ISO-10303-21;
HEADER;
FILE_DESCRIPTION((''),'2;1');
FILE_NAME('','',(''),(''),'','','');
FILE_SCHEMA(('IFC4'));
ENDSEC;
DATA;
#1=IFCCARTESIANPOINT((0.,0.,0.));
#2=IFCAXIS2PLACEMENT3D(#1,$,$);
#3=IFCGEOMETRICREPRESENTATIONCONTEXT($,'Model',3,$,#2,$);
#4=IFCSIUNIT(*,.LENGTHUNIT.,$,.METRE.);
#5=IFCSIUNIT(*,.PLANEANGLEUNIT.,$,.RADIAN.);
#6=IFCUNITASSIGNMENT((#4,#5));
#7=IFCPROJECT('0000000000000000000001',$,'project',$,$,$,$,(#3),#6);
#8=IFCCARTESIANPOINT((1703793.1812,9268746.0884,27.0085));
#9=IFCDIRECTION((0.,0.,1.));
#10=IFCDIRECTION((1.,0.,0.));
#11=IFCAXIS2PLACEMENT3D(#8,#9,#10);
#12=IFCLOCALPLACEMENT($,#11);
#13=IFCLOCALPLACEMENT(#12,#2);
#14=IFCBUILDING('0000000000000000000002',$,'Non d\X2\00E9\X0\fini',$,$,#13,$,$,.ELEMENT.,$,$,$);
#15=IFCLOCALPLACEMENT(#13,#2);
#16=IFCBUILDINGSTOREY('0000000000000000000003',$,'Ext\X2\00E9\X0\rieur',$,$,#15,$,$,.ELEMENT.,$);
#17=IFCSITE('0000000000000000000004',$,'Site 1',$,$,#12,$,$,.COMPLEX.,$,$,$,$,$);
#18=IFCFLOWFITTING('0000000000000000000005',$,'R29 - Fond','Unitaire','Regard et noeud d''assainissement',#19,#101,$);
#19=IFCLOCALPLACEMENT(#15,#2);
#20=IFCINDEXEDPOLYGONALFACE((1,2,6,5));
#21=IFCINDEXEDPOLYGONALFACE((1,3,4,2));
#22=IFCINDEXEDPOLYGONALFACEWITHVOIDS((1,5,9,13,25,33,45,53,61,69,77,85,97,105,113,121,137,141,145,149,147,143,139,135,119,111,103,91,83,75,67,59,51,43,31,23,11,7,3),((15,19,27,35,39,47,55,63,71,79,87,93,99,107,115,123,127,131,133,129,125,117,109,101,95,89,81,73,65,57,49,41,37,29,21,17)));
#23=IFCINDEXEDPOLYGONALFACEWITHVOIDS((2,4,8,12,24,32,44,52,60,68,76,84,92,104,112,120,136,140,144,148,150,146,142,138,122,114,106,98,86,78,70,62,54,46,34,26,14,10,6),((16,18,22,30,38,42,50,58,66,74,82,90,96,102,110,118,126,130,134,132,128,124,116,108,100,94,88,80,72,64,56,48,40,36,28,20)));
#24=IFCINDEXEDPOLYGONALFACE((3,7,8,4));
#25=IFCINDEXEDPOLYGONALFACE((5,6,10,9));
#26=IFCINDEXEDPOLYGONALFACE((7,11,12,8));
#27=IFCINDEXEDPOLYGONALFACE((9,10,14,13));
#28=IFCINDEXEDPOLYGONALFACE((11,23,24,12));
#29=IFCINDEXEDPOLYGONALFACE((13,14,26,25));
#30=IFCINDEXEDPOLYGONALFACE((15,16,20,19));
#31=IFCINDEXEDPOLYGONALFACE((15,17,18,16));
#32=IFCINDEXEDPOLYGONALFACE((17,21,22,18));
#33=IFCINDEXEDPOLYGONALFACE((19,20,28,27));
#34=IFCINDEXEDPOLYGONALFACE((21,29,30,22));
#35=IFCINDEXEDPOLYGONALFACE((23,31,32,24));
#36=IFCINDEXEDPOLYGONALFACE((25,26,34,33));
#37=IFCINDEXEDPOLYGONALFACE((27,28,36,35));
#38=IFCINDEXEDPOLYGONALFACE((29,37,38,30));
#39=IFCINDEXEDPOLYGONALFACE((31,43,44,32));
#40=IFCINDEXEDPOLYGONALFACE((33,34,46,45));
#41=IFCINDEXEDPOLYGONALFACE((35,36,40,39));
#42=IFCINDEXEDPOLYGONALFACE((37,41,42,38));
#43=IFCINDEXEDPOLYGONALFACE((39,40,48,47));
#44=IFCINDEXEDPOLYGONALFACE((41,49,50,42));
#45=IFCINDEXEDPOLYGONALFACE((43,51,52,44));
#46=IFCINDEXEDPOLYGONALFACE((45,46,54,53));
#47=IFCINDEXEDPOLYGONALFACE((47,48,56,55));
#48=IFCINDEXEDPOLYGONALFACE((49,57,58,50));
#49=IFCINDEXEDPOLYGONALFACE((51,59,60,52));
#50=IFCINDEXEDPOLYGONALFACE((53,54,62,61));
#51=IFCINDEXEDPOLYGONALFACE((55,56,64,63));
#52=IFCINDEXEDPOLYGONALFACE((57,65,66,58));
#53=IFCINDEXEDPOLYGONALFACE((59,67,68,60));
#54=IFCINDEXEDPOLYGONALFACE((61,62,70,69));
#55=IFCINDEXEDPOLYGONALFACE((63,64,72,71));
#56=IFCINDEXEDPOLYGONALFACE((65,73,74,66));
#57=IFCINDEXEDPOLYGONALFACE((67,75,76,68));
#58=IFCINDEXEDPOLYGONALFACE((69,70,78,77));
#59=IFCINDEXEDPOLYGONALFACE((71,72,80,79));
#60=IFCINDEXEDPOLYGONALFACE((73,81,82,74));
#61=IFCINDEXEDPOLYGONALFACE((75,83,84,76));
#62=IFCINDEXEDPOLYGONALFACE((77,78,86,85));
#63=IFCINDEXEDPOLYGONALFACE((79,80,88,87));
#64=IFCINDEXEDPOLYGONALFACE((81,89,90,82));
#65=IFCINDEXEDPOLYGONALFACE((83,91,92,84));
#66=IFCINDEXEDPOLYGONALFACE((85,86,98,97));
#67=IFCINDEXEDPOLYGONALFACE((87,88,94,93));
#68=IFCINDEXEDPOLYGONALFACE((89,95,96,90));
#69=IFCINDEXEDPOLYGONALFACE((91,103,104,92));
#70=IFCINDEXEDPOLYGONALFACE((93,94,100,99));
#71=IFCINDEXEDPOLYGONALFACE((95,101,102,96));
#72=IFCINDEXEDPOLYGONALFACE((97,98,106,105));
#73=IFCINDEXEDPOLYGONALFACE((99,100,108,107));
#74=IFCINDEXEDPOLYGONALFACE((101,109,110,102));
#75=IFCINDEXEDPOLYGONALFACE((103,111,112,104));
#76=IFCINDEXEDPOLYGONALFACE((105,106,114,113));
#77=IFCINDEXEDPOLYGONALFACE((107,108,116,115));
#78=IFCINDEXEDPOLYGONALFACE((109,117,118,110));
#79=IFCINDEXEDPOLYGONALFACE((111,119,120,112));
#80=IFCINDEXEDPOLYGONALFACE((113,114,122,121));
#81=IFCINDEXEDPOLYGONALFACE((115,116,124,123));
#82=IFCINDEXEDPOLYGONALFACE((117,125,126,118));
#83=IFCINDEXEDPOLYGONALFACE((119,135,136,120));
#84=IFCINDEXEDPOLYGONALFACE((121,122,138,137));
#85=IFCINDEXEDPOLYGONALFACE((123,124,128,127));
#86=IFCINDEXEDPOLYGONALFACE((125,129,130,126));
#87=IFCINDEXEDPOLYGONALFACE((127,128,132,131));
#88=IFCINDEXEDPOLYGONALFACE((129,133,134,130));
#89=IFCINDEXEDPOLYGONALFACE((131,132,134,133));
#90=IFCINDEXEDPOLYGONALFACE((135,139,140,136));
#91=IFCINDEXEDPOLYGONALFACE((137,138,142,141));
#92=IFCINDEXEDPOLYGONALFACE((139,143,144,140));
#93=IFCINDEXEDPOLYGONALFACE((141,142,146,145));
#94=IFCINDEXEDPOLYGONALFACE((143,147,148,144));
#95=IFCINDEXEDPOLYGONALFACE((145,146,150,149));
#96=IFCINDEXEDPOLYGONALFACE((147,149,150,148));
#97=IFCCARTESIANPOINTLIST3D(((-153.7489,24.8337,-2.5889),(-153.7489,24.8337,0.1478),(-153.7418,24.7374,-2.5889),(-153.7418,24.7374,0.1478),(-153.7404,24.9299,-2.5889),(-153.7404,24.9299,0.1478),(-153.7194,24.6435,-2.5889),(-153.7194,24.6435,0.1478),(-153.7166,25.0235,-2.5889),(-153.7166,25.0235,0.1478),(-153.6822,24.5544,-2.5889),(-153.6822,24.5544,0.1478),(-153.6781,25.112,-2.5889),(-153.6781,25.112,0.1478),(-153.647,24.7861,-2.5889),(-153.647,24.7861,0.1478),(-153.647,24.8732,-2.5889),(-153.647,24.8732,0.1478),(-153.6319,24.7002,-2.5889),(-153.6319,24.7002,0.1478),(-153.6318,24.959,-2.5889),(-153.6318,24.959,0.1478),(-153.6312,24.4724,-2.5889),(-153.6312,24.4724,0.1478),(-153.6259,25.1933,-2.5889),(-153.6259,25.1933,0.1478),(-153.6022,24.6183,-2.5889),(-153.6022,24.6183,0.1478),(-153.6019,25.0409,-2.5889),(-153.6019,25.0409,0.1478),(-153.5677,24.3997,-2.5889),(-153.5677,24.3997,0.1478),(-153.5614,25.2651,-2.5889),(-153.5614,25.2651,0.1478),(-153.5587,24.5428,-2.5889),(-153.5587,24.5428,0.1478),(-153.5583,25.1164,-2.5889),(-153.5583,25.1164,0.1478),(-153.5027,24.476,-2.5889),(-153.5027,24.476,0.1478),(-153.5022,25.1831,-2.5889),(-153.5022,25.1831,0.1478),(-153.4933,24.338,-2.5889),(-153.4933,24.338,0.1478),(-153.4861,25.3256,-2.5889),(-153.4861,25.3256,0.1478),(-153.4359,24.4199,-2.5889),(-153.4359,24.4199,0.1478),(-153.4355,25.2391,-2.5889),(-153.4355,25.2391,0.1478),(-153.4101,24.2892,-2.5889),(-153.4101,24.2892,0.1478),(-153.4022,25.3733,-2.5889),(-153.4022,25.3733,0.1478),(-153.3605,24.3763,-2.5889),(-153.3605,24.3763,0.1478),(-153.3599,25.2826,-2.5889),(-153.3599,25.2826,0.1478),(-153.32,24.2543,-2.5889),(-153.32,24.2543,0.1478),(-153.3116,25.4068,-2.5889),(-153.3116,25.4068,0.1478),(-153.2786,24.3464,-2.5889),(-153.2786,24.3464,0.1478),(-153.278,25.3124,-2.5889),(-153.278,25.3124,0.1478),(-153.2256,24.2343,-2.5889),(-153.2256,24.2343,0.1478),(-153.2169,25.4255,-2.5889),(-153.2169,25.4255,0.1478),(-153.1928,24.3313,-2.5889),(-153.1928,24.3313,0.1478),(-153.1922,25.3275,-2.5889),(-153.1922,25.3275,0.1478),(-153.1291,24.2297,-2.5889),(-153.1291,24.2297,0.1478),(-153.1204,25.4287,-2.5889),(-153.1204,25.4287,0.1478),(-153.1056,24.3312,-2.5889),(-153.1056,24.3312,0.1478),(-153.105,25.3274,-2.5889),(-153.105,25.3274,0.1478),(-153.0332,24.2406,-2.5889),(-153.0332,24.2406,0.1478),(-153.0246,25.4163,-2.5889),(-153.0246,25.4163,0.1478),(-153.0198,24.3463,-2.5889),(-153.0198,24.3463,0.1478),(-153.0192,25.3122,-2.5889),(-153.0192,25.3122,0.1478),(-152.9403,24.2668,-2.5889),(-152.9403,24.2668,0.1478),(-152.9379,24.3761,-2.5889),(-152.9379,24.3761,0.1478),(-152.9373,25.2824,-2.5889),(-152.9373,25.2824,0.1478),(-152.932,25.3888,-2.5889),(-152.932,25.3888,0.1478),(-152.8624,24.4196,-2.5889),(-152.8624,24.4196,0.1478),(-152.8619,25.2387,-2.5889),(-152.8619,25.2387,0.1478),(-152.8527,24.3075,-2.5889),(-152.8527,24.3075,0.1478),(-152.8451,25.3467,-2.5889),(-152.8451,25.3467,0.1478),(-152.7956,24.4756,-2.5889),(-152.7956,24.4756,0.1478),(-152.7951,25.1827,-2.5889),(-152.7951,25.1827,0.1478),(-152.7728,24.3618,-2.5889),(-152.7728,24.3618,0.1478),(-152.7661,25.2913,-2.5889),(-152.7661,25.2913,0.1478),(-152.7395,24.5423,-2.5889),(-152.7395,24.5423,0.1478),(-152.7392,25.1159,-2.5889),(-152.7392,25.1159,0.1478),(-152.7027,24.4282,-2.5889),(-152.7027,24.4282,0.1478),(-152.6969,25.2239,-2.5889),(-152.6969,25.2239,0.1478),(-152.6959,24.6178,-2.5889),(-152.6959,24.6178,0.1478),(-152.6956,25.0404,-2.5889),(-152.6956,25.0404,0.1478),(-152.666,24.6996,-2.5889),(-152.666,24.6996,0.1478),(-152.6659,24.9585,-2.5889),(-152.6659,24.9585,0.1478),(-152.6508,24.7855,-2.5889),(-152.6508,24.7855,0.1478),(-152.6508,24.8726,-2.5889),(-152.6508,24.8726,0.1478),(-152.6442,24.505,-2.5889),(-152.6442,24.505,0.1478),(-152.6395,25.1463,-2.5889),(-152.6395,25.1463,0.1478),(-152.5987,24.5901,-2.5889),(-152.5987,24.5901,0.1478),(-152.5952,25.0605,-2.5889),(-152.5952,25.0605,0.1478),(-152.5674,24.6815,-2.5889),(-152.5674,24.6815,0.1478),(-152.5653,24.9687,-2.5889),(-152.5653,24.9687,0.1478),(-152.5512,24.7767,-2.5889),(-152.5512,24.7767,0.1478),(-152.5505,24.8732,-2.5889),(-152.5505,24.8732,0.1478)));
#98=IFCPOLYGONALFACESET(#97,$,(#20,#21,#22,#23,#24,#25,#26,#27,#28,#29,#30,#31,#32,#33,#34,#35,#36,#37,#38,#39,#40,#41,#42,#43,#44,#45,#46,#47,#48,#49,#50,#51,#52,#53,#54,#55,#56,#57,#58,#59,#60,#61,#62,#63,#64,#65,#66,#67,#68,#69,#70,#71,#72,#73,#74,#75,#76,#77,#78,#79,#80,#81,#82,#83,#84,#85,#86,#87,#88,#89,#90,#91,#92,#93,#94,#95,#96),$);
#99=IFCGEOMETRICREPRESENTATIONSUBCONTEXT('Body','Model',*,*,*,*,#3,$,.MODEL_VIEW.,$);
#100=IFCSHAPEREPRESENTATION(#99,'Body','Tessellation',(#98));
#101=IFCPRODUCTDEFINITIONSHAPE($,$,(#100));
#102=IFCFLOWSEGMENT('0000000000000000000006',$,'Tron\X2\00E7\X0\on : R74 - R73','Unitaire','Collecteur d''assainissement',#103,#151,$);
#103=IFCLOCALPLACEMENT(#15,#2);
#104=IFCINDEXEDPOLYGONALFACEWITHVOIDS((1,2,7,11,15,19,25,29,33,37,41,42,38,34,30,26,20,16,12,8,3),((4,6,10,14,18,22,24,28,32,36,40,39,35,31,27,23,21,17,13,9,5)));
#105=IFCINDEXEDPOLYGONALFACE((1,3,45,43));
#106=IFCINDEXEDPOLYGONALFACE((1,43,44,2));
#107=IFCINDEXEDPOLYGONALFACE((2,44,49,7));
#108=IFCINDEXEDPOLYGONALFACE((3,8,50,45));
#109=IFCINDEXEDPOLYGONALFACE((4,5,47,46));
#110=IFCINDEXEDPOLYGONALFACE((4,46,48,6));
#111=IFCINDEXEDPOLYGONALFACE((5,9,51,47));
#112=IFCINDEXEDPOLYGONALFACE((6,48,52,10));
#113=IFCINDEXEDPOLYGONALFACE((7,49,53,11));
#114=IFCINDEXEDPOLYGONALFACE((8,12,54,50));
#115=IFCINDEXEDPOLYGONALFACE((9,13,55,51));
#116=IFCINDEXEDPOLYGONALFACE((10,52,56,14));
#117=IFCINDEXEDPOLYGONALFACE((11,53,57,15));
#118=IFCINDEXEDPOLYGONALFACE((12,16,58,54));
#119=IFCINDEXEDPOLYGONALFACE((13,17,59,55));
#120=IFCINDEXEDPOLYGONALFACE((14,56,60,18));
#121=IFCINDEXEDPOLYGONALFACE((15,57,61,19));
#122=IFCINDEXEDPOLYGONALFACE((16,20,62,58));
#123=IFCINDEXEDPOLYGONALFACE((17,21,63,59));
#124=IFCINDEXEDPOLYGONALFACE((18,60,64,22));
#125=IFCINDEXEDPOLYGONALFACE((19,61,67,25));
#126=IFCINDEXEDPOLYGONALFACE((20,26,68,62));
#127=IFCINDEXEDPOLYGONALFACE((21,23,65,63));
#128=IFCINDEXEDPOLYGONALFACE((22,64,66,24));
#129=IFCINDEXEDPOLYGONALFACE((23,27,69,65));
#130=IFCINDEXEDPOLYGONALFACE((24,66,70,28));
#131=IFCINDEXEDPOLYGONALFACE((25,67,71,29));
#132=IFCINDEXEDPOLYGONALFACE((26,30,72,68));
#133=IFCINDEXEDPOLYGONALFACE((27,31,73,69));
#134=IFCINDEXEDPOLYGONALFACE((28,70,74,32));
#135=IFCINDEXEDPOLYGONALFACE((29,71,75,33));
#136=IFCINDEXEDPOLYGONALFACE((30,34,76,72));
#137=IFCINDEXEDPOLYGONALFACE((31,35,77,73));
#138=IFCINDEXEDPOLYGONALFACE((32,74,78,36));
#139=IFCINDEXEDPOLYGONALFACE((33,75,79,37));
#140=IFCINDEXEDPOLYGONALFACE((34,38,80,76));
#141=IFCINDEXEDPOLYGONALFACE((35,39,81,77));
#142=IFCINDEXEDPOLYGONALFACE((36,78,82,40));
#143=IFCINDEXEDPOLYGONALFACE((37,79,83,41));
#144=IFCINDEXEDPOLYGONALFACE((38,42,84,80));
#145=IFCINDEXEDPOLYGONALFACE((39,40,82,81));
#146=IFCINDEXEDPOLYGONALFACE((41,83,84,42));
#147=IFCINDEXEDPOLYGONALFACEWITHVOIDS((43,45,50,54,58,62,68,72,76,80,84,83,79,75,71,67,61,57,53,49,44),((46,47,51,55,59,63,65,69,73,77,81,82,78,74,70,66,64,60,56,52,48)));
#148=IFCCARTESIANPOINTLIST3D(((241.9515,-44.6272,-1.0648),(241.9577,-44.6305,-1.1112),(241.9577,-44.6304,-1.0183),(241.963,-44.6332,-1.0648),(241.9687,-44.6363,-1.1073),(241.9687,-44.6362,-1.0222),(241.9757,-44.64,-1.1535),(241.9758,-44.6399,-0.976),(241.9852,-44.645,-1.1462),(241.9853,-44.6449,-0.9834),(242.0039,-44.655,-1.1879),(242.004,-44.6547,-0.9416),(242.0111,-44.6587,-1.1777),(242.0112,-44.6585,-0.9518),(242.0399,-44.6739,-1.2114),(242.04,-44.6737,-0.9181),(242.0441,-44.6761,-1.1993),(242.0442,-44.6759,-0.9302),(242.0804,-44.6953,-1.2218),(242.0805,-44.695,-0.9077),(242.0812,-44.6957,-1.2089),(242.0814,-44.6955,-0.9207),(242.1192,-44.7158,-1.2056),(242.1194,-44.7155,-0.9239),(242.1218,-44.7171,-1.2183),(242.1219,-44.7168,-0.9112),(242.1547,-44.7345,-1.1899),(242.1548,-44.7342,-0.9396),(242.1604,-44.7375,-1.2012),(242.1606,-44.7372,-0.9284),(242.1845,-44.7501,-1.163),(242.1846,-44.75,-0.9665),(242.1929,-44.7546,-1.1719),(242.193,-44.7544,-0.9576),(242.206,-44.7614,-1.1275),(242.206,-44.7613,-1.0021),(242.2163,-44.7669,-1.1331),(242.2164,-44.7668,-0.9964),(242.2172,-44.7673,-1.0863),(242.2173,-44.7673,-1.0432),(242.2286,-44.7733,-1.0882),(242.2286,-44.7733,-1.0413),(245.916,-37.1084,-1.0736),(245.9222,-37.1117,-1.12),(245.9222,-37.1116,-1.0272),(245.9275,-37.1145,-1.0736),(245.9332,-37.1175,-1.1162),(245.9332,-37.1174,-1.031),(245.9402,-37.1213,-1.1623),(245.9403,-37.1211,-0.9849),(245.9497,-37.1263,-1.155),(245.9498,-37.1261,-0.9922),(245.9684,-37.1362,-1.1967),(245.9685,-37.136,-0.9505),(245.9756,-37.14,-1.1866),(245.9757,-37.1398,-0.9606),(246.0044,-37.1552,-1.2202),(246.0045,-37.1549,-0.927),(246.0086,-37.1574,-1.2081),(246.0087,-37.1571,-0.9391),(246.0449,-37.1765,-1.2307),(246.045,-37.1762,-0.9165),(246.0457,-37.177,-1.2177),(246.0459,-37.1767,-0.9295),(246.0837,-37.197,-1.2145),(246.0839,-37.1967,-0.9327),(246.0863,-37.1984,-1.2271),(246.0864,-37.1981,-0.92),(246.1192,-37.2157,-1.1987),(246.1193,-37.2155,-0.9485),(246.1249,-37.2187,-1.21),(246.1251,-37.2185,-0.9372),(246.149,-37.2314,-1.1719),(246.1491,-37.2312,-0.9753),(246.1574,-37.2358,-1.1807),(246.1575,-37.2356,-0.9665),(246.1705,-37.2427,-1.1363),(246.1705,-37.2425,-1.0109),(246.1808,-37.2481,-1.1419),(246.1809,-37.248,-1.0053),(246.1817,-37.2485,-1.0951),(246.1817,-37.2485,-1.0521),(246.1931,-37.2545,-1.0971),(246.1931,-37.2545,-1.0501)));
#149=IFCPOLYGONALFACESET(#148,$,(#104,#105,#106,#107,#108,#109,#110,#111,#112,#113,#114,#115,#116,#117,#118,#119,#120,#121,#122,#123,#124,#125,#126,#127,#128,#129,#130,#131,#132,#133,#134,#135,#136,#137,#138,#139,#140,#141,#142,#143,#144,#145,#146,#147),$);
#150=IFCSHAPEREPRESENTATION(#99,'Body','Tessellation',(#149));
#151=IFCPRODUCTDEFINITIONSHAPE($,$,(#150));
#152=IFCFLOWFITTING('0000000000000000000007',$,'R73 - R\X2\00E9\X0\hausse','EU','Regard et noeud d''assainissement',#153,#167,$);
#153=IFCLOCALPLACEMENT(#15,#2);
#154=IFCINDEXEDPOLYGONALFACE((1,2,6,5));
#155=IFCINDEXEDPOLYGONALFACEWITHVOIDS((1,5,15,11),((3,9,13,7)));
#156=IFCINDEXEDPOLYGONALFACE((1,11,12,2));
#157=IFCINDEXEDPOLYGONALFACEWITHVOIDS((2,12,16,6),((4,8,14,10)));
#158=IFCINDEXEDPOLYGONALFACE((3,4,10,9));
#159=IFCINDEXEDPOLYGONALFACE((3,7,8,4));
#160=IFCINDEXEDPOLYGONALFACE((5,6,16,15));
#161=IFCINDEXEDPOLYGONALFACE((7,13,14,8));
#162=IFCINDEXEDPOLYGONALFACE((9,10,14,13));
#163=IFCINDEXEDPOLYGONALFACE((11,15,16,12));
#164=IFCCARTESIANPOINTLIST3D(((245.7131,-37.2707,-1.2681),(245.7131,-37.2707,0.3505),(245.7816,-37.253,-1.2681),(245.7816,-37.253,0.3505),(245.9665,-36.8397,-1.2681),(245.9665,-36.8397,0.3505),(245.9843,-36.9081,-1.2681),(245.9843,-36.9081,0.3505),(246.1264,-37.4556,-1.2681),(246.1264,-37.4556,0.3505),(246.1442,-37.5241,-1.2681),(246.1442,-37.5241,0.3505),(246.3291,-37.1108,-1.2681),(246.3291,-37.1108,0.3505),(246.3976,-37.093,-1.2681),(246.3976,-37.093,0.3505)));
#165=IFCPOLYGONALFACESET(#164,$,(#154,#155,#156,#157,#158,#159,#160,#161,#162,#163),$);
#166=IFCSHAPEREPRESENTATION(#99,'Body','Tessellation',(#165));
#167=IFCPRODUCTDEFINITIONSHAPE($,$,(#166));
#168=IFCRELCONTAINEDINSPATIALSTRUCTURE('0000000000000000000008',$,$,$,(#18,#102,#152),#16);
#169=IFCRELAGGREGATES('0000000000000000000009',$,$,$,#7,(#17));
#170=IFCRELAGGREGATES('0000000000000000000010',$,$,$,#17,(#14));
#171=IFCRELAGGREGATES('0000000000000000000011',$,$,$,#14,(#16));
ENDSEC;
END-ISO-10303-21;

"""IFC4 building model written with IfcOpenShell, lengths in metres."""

from ifc_helpers import new_model, si_unit, frame, origin, origin_2d, place, context, subcontext, project, spatial, hollow_rectangle, hollow_circle, extrude, element, save


model = new_model("IFC4")

# Units and contexts
model_context = context("Model", 3, world=origin())
body_context = subcontext(model_context, "Body", "Model", "MODEL_VIEW")
ifc_project = project(units=[si_unit("LENGTHUNIT", "METRE"), si_unit("PLANEANGLEUNIT", "RADIAN")], contexts=[model_context])

# Site, building, storey
site_placement = place(None, frame((1703793.1812, 9268746.0884, 27.0085), z_axis=(0.0, 0.0, 1.0), x_axis=(1.0, 0.0, 0.0)))
site = spatial("IfcSite", under=ifc_project, at=site_placement, Name="Site 1", CompositionType="COMPLEX")
building_placement = place(site_placement, origin())
building = spatial("IfcBuilding", under=site, at=building_placement, Name="Non défini", CompositionType="ELEMENT")
storey_placement = place(building_placement, origin())
storey = spatial("IfcBuildingStorey", under=building, at=storey_placement, Name="Extérieur", CompositionType="ELEMENT")

# Flow fitting
flow_fitting_1_placement = place(storey_placement, origin())
element("IfcFlowFitting", 1, at=flow_fitting_1_placement, inside=storey, Name="R29 - Fond", Description="Unitaire", ObjectType="Regard et noeud d'assainissement", context=body_context, shape_type="SweptSolid", body=[
    extrude(hollow_circle(Radius=0.6, WallThickness=0.1, at=origin_2d()), frame((-153.1489, 24.8293, -2.5889), z_axis=(0.0, 0.0, 1.0), x_axis=(0.996143, -0.08775, 0.0)), (0.0, 0.0, 1.0), 2.7366),
])

# Flow segment
flow_segment_1_placement = place(storey_placement, origin())
element("IfcFlowSegment", 2, at=flow_segment_1_placement, inside=storey, Name="Tronçon : R74 - R73", Description="Unitaire", ObjectType="Collecteur d'assainissement", context=body_context, shape_type="SweptSolid", body=[
    extrude(hollow_circle(Radius=0.1575, WallThickness=0.013, at=origin_2d()), frame((242.0908, -44.7006, -1.0648), z_axis=(0.466414, 0.884566, -0.00104), x_axis=(-0.884566, 0.466414, 0.0)), (0.0, 0.0, 1.0), 8.5),
])

# Flow fitting
for number, where, name in (
    (3, (0.0, 0.0, 0.0), "R73 - Réhausse"),
):
    element("IfcFlowFitting", number, at=place(storey_placement, frame(where)), inside=storey, Name=name, Description="EU", ObjectType="Regard et noeud d'assainissement", context=body_context, shape_type="SweptSolid", body=[
        extrude(hollow_rectangle(XDim=0.5, YDim=0.5, WallThickness=0.05, at=origin_2d()), frame((246.0553, -37.1819, -1.2681), z_axis=(0.0, 0.0, 1.0), x_axis=(0.862105, -0.50673, 0.0)), (0.0, 0.0, 1.0), 1.6186),
    ])

save(model, "model.ifc")
